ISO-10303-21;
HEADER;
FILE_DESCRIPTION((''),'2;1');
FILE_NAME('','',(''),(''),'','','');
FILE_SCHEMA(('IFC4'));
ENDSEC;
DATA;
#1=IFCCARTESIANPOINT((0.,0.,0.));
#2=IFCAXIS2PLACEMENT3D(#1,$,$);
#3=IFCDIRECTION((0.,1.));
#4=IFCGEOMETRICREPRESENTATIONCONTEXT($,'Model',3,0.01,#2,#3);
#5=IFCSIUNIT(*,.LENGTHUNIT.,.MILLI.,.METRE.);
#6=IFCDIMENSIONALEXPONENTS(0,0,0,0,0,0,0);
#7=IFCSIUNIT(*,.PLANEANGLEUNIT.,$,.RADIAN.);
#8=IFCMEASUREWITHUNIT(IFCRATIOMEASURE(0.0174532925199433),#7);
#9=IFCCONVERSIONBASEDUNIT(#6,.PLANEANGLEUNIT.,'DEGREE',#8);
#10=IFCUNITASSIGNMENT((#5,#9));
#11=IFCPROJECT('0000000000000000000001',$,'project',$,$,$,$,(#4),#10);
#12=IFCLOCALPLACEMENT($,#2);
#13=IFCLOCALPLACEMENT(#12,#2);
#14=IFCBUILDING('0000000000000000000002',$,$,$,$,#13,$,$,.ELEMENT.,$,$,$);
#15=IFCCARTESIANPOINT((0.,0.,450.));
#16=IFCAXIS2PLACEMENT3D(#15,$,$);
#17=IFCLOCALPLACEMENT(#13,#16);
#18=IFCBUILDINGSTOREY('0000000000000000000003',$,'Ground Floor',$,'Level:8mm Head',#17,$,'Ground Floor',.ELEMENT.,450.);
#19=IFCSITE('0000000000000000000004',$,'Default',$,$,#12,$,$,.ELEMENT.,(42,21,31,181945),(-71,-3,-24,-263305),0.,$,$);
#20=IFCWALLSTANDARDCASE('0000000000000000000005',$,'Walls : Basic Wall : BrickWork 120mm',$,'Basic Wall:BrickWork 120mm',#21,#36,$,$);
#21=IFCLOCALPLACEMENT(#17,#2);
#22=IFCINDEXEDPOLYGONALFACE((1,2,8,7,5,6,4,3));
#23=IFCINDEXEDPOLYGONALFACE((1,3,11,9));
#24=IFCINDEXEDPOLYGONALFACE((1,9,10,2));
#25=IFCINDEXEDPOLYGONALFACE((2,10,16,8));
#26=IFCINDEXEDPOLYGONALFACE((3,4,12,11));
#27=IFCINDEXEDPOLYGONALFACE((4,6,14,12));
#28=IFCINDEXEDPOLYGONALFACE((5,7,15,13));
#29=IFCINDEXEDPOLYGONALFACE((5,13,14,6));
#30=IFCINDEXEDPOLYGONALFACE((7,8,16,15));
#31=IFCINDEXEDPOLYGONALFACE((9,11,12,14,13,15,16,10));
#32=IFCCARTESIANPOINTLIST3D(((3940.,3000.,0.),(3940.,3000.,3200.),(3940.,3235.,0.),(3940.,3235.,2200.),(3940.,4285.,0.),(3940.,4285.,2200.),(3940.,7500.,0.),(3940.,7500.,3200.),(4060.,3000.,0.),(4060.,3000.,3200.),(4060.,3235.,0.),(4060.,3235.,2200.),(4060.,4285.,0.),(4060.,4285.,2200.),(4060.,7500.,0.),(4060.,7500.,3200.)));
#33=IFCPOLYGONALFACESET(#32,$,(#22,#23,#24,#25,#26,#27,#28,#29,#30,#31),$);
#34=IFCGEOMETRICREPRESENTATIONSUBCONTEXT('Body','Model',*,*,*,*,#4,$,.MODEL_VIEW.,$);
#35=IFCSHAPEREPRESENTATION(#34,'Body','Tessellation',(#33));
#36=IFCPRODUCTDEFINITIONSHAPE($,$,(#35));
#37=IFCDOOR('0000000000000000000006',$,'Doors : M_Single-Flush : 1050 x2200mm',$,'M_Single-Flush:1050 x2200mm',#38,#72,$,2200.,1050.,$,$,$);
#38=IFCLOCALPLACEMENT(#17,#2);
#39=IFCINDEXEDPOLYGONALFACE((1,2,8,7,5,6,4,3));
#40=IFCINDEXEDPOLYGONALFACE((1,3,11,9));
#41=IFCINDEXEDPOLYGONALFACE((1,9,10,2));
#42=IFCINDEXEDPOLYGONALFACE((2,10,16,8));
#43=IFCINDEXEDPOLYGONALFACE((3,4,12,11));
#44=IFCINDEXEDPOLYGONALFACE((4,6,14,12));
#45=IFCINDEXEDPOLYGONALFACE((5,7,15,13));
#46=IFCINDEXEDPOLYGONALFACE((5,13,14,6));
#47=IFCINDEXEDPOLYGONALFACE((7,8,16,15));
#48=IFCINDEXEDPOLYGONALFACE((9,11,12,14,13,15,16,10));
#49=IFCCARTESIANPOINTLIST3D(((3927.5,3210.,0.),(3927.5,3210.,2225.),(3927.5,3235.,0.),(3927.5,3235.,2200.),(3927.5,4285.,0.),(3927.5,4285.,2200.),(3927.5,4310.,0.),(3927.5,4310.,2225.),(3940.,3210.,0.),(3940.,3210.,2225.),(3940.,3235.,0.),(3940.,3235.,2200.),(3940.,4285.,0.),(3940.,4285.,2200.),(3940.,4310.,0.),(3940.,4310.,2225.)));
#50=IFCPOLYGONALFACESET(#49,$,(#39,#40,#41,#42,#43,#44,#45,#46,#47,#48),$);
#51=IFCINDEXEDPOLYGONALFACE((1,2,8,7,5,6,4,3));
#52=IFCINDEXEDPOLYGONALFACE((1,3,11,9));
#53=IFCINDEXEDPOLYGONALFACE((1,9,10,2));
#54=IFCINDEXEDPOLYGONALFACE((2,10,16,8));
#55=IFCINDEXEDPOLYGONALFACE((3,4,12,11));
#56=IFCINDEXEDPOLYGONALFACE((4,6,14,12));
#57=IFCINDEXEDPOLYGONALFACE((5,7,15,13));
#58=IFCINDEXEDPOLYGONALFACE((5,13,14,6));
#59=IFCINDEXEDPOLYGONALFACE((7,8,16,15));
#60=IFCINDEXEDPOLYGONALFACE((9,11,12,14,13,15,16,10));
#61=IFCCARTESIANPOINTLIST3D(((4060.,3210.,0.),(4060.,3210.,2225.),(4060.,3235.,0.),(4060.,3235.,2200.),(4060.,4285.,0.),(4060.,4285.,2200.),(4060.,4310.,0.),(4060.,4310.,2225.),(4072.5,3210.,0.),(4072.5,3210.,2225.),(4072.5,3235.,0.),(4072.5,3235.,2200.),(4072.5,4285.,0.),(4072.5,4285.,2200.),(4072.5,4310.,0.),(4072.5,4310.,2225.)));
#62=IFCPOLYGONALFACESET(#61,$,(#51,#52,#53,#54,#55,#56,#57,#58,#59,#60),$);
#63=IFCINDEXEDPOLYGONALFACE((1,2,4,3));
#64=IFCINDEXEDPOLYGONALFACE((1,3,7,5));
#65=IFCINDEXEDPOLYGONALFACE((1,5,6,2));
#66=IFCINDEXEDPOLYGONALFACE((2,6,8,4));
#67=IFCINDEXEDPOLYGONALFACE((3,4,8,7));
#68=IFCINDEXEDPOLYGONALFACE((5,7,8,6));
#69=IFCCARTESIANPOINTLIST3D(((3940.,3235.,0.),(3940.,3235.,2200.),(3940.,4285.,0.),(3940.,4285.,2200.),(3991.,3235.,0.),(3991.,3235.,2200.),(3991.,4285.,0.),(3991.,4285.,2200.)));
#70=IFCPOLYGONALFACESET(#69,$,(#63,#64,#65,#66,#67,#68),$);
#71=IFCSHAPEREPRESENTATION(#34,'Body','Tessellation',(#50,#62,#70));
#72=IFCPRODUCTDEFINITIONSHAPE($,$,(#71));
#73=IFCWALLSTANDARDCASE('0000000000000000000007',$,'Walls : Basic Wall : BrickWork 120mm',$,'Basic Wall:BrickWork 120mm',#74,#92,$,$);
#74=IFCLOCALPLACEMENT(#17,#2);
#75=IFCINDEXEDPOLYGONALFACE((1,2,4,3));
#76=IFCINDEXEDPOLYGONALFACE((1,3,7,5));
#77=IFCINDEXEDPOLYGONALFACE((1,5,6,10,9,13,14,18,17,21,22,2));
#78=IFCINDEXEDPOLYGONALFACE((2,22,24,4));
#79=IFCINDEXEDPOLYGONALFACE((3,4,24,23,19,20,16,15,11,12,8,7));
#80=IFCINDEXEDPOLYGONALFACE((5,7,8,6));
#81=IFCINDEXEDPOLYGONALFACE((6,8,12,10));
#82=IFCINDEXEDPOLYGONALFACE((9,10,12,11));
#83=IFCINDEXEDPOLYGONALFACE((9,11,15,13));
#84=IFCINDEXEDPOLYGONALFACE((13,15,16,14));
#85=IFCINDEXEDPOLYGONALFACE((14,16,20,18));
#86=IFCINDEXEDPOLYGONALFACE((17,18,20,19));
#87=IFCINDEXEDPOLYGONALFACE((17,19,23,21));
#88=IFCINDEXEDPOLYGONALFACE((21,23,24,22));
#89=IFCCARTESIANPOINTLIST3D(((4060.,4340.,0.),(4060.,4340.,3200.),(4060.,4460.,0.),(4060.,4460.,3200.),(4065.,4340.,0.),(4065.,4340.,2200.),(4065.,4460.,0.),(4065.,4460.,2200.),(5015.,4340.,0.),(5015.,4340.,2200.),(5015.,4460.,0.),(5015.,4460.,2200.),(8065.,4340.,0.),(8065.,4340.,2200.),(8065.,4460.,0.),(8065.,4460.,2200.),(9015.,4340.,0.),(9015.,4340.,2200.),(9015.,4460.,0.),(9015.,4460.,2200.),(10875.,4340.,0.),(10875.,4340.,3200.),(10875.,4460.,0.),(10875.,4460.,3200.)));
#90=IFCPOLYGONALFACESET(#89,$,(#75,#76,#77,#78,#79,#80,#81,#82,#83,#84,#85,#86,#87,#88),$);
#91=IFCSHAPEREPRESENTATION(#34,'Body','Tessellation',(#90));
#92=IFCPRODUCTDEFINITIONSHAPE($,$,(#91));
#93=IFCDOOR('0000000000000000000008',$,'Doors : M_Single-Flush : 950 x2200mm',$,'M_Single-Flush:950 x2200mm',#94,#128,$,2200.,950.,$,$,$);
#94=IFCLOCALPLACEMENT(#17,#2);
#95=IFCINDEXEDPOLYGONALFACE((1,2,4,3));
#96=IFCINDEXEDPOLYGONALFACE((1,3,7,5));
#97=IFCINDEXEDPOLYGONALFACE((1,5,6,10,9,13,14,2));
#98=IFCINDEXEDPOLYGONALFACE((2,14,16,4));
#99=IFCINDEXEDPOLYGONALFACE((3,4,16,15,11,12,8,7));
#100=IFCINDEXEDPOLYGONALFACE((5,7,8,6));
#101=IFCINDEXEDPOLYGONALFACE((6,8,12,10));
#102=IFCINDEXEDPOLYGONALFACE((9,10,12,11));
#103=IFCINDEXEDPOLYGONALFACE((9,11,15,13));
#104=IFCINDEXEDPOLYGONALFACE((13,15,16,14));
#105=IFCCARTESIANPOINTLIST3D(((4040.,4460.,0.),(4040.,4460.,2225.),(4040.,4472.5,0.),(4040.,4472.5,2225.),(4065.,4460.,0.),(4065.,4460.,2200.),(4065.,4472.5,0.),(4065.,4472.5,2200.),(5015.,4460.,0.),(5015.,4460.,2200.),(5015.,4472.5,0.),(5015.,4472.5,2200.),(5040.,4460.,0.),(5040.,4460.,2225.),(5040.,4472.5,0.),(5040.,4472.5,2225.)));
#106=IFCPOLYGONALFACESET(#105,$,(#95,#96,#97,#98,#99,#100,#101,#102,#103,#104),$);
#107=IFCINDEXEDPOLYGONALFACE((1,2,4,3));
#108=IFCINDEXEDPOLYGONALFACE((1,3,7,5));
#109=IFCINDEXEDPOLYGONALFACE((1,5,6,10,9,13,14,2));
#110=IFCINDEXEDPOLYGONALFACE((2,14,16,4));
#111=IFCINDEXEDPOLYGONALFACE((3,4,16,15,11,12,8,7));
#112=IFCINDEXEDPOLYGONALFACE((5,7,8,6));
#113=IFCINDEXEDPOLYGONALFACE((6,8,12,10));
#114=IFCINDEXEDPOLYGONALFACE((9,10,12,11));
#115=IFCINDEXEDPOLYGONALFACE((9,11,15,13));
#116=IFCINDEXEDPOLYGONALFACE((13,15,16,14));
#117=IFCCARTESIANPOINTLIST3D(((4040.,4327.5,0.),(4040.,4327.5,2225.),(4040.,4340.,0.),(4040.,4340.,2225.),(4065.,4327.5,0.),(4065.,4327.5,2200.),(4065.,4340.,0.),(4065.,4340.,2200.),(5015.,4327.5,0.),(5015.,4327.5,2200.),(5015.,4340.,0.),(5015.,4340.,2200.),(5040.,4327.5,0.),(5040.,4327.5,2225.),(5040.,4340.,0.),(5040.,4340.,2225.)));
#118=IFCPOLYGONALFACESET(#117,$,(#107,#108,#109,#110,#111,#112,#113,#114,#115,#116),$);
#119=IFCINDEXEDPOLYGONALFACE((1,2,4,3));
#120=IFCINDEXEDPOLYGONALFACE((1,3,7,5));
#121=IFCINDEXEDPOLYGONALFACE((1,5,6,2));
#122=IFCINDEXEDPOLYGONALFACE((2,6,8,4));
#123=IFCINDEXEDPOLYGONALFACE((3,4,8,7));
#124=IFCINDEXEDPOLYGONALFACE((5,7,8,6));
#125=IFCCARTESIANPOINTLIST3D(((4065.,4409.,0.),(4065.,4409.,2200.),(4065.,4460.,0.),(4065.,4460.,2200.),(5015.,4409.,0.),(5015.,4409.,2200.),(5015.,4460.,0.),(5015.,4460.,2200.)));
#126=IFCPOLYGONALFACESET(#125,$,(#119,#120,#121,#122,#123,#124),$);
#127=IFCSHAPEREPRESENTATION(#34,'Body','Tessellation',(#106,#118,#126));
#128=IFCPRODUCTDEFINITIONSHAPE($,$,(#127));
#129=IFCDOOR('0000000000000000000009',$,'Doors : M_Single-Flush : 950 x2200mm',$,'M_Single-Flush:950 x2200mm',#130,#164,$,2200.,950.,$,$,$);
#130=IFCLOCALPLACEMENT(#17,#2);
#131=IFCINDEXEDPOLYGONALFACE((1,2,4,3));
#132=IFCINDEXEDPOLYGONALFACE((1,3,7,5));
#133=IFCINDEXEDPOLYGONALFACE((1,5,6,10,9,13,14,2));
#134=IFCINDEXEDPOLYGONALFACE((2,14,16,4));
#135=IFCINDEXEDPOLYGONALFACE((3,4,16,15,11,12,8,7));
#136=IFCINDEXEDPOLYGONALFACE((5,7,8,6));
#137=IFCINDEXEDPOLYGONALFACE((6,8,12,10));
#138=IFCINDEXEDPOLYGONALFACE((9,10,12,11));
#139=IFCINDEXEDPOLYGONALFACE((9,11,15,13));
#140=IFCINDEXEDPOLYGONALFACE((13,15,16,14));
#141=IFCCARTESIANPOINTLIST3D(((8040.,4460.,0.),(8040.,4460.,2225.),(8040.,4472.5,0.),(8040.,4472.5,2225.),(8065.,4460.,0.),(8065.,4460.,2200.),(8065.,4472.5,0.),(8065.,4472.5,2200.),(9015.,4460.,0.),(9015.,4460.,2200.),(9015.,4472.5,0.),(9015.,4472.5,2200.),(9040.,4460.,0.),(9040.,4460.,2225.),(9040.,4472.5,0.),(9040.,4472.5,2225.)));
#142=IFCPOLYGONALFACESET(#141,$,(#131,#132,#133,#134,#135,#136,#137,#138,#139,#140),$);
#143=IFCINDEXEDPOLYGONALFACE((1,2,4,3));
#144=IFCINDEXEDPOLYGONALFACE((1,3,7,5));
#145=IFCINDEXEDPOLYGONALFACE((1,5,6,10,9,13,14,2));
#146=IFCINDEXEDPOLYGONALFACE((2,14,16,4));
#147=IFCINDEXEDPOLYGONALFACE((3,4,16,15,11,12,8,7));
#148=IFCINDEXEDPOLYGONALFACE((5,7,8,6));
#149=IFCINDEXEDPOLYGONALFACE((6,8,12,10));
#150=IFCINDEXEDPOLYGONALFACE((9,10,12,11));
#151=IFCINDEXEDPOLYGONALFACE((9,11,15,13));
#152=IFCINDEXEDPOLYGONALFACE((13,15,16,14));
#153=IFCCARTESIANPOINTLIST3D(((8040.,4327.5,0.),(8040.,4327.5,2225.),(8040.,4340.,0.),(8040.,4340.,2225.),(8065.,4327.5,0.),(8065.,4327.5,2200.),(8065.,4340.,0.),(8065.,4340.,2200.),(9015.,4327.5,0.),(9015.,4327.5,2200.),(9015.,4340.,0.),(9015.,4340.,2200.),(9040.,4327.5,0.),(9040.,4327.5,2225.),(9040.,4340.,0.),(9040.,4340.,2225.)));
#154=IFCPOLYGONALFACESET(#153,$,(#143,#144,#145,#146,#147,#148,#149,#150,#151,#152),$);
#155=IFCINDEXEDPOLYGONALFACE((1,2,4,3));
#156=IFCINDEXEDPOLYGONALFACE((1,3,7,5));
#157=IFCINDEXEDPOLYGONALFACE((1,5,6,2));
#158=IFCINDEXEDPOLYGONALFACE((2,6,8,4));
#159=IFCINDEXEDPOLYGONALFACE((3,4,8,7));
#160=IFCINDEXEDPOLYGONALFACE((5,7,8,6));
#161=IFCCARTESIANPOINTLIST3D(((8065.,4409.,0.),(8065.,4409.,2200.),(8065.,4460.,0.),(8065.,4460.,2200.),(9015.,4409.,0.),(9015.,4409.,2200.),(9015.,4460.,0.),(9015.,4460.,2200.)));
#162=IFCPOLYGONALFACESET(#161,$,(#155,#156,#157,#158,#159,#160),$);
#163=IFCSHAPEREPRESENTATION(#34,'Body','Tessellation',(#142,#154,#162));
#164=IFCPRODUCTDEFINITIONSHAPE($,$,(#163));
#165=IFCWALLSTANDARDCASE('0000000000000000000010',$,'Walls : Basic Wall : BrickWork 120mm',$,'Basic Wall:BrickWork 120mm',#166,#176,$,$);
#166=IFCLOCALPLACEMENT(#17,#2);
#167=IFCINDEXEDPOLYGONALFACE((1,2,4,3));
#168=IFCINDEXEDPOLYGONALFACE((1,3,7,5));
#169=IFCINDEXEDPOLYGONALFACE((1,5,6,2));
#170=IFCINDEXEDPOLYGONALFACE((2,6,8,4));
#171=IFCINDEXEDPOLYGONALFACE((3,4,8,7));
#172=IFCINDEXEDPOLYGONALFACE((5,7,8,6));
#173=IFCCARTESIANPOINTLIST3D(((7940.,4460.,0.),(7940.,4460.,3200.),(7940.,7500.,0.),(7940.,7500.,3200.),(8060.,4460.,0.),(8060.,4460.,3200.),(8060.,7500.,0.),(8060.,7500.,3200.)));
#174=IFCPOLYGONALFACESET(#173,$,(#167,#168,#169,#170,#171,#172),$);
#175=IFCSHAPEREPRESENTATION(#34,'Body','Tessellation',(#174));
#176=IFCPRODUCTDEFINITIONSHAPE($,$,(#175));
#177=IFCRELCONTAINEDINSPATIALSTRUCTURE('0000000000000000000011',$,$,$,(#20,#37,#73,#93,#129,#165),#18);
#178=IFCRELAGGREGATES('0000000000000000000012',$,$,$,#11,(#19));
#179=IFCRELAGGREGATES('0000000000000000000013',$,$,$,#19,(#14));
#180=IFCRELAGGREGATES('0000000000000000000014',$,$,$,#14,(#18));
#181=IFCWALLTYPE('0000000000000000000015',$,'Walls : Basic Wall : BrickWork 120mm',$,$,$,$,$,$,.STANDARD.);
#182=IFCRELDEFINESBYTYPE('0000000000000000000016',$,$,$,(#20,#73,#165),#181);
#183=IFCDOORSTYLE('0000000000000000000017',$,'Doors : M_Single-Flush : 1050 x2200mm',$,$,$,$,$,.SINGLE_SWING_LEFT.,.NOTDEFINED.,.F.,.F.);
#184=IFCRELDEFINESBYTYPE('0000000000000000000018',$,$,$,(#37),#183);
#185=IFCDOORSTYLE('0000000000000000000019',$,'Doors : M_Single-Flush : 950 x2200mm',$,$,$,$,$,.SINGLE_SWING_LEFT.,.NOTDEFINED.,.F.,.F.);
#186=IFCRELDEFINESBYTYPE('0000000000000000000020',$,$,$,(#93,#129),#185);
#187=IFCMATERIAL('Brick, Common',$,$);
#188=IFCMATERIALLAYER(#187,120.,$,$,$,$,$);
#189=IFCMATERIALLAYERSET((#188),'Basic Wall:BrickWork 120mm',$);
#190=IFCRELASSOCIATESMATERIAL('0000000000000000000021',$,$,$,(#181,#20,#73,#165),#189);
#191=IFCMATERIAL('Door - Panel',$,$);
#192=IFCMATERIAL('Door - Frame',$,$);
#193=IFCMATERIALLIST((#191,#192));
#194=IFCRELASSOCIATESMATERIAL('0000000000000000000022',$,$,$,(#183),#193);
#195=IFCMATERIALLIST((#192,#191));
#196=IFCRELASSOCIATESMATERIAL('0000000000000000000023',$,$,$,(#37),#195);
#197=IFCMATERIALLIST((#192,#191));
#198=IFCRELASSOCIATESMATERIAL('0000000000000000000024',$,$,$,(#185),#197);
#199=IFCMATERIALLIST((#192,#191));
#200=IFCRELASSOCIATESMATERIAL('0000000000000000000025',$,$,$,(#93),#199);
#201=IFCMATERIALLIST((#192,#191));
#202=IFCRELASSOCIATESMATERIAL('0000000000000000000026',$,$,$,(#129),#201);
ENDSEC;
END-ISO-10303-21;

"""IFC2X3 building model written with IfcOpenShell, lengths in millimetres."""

from ifc_helpers import new_model, entity, si_unit, converted_unit, direction, frame, frame_2d, origin, place, context, subcontext, project, spatial, polyline, rectangle, outline, extrude, source, transform, mapped, material, material_list, layer, layer_set, layer_usage, type_object, type_shapes, element, fill, save


model = new_model("IFC2X3")

# Units and contexts
model_context = context("Model", 3, precision=0.01, world=origin(), true_north=direction((0.0, 1.0)))
body_context = subcontext(model_context, "Body", "Model", "MODEL_VIEW")
ifc_project = project(units=[si_unit("LENGTHUNIT", "METRE", prefix="MILLI"), converted_unit("PLANEANGLEUNIT", "DEGREE", entity("IfcRatioMeasure", 0.0174532925199433), si_unit("PLANEANGLEUNIT", "RADIAN"), dimensions=[0, 0, 0, 0, 0, 0, 0])], contexts=[model_context])

# Site, building, storey
site_placement = place(None, origin())
site = spatial("IfcSite", under=ifc_project, at=site_placement, Name="Default", CompositionType="ELEMENT", RefLatitude=(42, 21, 31, 181945), RefLongitude=(-71, -3, -24, -263305), RefElevation=0.0)
building_placement = place(site_placement, origin())
building = spatial("IfcBuilding", under=site, at=building_placement, CompositionType="ELEMENT")
storey_placement = place(building_placement, frame((0.0, 0.0, 450.0)))
storey = spatial("IfcBuildingStorey", under=building, at=storey_placement, Name="Ground Floor", ObjectType="Level:8mm Head", LongName="Ground Floor", CompositionType="ELEMENT", Elevation=450.0)

# Wall, opening, door
ifc_material_1 = material(Name="Brick, Common")
ifc_layer_1 = layer(ifc_material_1, 120.0)
ifc_layer_set_1 = layer_set([ifc_layer_1], Name="Basic Wall:BrickWork 120mm")
ifc_layer_usage_1 = layer_usage(ifc_layer_set_1, "AXIS2", "NEGATIVE", 60.0)
wall_type = type_object("IfcWallType", Name="Walls : Basic Wall : BrickWork 120mm", PredefinedType="STANDARD", material=ifc_layer_set_1)
wall_1_placement = place(storey_placement, frame((4000.0, 7500.0, 0.0), z_axis=(0.0, 0.0, 1.0), x_axis=(0.0, -1.0, 0.0)))
wall_1 = element("IfcWallStandardCase", 1, at=wall_1_placement, inside=storey, type_object=wall_type, material=ifc_layer_usage_1, Name="Walls : Basic Wall : BrickWork 120mm", ObjectType="Basic Wall:BrickWork 120mm", context=body_context, shape_type="SweptSolid", body=[
    extrude(rectangle(XDim=4500.0, YDim=120.0, at=frame_2d((2250.0, 0.0), x_axis=(-1.0, 0.0))), origin(), (0.0, 0.0, 1.0), 3200.0),
])
opening_1_placement = place(wall_1_placement, frame((4265.0, 60.0, 0.0)))
opening_1 = element("IfcOpeningElement", 2, at=opening_1_placement, cuts=wall_1, ObjectType="Opening", context=body_context, shape_type="SweptSolid", body=[
    extrude(rectangle(XDim=1050.0, YDim=2200.0, at=frame_2d((1100.0, 525.0), x_axis=(0.0, -1.0))), frame((0.0, 0.0, 0.0), z_axis=(0.0, -1.0, 0.0), x_axis=(0.0, 0.0, 1.0)), (0.0, 0.0, 1.0), 120.0),
])
ifc_material_2 = material(Name="Door - Frame")
ifc_material_3 = material(Name="Door - Panel")
ifc_material_list_1 = material_list([ifc_material_2, ifc_material_3])
ifc_material_list_2 = material_list([ifc_material_3, ifc_material_2])
door_style_1 = type_object("IfcDoorStyle", Name="Doors : M_Single-Flush : 1050 x2200mm", ConstructionType="NOTDEFINED", OperationType="SINGLE_SWING_LEFT", ParameterTakesPrecedence=False, Sizeable=False, material=ifc_material_list_2)
shared_shape_1 = source(origin(), body_context, "Body", "SweptSolid", [
    extrude(outline(polyline([(-550.0, -1118.8), (550.0, -1118.8), (550.0, 1106.2), (525.0, 1106.2), (525.0, -1093.8), (-525.0, -1093.8), (-525.0, 1106.2), (-550.0, 1106.2), (-550.0, -1118.8)])), frame((525.0, 132.5, 1106.2), z_axis=(0.0, -1.0, 0.0), x_axis=(-1.0, 0.0, 0.0)), (0.0, 0.0, 1.0), 12.5),
    extrude(outline(polyline([(-1118.8, -550.0), (1106.2, -550.0), (1106.2, -525.0), (-1093.8, -525.0), (-1093.8, 525.0), (1106.2, 525.0), (1106.2, 550.0), (-1118.8, 550.0), (-1118.8, -550.0)])), frame((525.0, 0.0, 1106.2), z_axis=(0.0, -1.0, 0.0), x_axis=(0.0, 0.0, -1.0)), (0.0, 0.0, 1.0), 12.5),
    extrude(rectangle(XDim=1050.0, YDim=51.0, at=frame_2d((0.0, 0.0), x_axis=(1.0, 0.0))), frame((525.0, 94.5, 0.0)), (0.0, 0.0, 1.0), 2200.0),
])
type_shapes(door_style_1, [shared_shape_1])
door_1_placement = place(opening_1_placement, frame((0.0, 0.0, 0.0), z_axis=(0.0, 0.0, 1.0), x_axis=(-1.0, 0.0, 0.0)))
door_1 = element("IfcDoor", 3, at=door_1_placement, inside=storey, type_object=door_style_1, material=ifc_material_list_1, Name="Doors : M_Single-Flush : 1050 x2200mm", ObjectType="M_Single-Flush:1050 x2200mm", OverallHeight=2200.0, OverallWidth=1050.0, context=body_context, shape_type="MappedRepresentation", body=[
    mapped(shared_shape_1, transform((0.0, 0.0, 0.0), scale=1.0)),
])
fill(opening_1, door_1)

# Wall, openings, doors
ifc_layer_usage_2 = layer_usage(ifc_layer_set_1, "AXIS2", "NEGATIVE", 60.0)
wall_2_placement = place(storey_placement, frame((10875.0, 4400.0, 0.0), z_axis=(0.0, 0.0, 1.0), x_axis=(-1.0, 0.0, 0.0)))
wall_2 = element("IfcWallStandardCase", 4, at=wall_2_placement, inside=storey, type_object=wall_type, material=ifc_layer_usage_2, Name="Walls : Basic Wall : BrickWork 120mm", ObjectType="Basic Wall:BrickWork 120mm", context=body_context, shape_type="SweptSolid", body=[
    extrude(rectangle(XDim=6815.0, YDim=120.0, at=frame_2d((3407.5, 0.0), x_axis=(-1.0, 0.0))), origin(), (0.0, 0.0, 1.0), 3200.0),
])
opening_2_placement = place(wall_2_placement, frame((6810.0, 60.0, 0.0)))
opening_2 = element("IfcOpeningElement", 5, at=opening_2_placement, cuts=wall_2, ObjectType="Opening", context=body_context, shape_type="SweptSolid", body=[
    extrude(rectangle(XDim=950.0, YDim=2200.0, at=frame_2d((1100.0, 475.0), x_axis=(0.0, -1.0))), frame((0.0, 0.0, 0.0), z_axis=(0.0, -1.0, 0.0), x_axis=(0.0, 0.0, 1.0)), (0.0, 0.0, 1.0), 120.0),
])
opening_3_placement = place(wall_2_placement, frame((2810.0, 60.0, 0.0)))
opening_3 = element("IfcOpeningElement", 6, at=opening_3_placement, cuts=wall_2, ObjectType="Opening", context=body_context, shape_type="SweptSolid", body=[
    extrude(rectangle(XDim=950.0, YDim=2200.0, at=frame_2d((1100.0, 475.0), x_axis=(0.0, -1.0))), frame((0.0, 0.0, 0.0), z_axis=(0.0, -1.0, 0.0), x_axis=(0.0, 0.0, 1.0)), (0.0, 0.0, 1.0), 120.0),
])
ifc_material_list_3 = material_list([ifc_material_2, ifc_material_3])
ifc_material_list_4 = material_list([ifc_material_2, ifc_material_3])
door_style_2 = type_object("IfcDoorStyle", Name="Doors : M_Single-Flush : 950 x2200mm", ConstructionType="NOTDEFINED", OperationType="SINGLE_SWING_LEFT", ParameterTakesPrecedence=False, Sizeable=False, material=ifc_material_list_4)
shared_shape_2 = source(origin(), body_context, "Body", "SweptSolid", [
    extrude(outline(polyline([(-500.0, -1118.8), (500.0, -1118.8), (500.0, 1106.2), (475.0, 1106.2), (475.0, -1093.8), (-475.0, -1093.8), (-475.0, 1106.2), (-500.0, 1106.2), (-500.0, -1118.8)])), frame((475.0, 132.5, 1106.2), z_axis=(0.0, -1.0, 0.0), x_axis=(-1.0, 0.0, 0.0)), (0.0, 0.0, 1.0), 12.5),
    extrude(outline(polyline([(-1118.8, -500.0), (1106.2, -500.0), (1106.2, -475.0), (-1093.8, -475.0), (-1093.8, 475.0), (1106.2, 475.0), (1106.2, 500.0), (-1118.8, 500.0), (-1118.8, -500.0)])), frame((475.0, 0.0, 1106.2), z_axis=(0.0, -1.0, 0.0), x_axis=(0.0, 0.0, -1.0)), (0.0, 0.0, 1.0), 12.5),
    extrude(rectangle(XDim=950.0, YDim=51.0, at=frame_2d((0.0, 0.0), x_axis=(1.0, 0.0))), frame((475.0, 94.5, 0.0)), (0.0, 0.0, 1.0), 2200.0),
])
type_shapes(door_style_2, [shared_shape_2])
door_2_placement = place(opening_2_placement, frame((0.0, 0.0, 0.0), z_axis=(0.0, 0.0, 1.0), x_axis=(-1.0, 0.0, 0.0)))
door_2 = element("IfcDoor", 7, at=door_2_placement, inside=storey, type_object=door_style_2, material=ifc_material_list_3, Name="Doors : M_Single-Flush : 950 x2200mm", ObjectType="M_Single-Flush:950 x2200mm", OverallHeight=2200.0, OverallWidth=950.0, context=body_context, shape_type="MappedRepresentation", body=[
    mapped(shared_shape_2, transform((0.0, 0.0, 0.0), scale=1.0)),
])
fill(opening_2, door_2)
ifc_material_list_5 = material_list([ifc_material_2, ifc_material_3])
door_3_placement = place(opening_3_placement, frame((0.0, 0.0, 0.0), z_axis=(0.0, 0.0, 1.0), x_axis=(-1.0, 0.0, 0.0)))
door_3 = element("IfcDoor", 8, at=door_3_placement, inside=storey, type_object=door_style_2, material=ifc_material_list_5, Name="Doors : M_Single-Flush : 950 x2200mm", ObjectType="M_Single-Flush:950 x2200mm", OverallHeight=2200.0, OverallWidth=950.0, context=body_context, shape_type="MappedRepresentation", body=[
    mapped(shared_shape_2, transform((0.0, 0.0, 0.0), scale=1.0)),
])
fill(opening_3, door_3)

# Wall
ifc_layer_usage_3 = layer_usage(ifc_layer_set_1, "AXIS2", "NEGATIVE", 60.0)
wall_3_placement = place(storey_placement, frame((8000.0, 7500.0, 0.0), z_axis=(0.0, 0.0, 1.0), x_axis=(0.0, -1.0, 0.0)))
element("IfcWallStandardCase", 9, at=wall_3_placement, inside=storey, type_object=wall_type, material=ifc_layer_usage_3, Name="Walls : Basic Wall : BrickWork 120mm", ObjectType="Basic Wall:BrickWork 120mm", context=body_context, shape_type="SweptSolid", body=[
    extrude(rectangle(XDim=3040.0, YDim=120.0, at=frame_2d((1520.0, 0.0), x_axis=(-1.0, 0.0))), origin(), (0.0, 0.0, 1.0), 3200.0),
])

save(model, "model.ifc")
